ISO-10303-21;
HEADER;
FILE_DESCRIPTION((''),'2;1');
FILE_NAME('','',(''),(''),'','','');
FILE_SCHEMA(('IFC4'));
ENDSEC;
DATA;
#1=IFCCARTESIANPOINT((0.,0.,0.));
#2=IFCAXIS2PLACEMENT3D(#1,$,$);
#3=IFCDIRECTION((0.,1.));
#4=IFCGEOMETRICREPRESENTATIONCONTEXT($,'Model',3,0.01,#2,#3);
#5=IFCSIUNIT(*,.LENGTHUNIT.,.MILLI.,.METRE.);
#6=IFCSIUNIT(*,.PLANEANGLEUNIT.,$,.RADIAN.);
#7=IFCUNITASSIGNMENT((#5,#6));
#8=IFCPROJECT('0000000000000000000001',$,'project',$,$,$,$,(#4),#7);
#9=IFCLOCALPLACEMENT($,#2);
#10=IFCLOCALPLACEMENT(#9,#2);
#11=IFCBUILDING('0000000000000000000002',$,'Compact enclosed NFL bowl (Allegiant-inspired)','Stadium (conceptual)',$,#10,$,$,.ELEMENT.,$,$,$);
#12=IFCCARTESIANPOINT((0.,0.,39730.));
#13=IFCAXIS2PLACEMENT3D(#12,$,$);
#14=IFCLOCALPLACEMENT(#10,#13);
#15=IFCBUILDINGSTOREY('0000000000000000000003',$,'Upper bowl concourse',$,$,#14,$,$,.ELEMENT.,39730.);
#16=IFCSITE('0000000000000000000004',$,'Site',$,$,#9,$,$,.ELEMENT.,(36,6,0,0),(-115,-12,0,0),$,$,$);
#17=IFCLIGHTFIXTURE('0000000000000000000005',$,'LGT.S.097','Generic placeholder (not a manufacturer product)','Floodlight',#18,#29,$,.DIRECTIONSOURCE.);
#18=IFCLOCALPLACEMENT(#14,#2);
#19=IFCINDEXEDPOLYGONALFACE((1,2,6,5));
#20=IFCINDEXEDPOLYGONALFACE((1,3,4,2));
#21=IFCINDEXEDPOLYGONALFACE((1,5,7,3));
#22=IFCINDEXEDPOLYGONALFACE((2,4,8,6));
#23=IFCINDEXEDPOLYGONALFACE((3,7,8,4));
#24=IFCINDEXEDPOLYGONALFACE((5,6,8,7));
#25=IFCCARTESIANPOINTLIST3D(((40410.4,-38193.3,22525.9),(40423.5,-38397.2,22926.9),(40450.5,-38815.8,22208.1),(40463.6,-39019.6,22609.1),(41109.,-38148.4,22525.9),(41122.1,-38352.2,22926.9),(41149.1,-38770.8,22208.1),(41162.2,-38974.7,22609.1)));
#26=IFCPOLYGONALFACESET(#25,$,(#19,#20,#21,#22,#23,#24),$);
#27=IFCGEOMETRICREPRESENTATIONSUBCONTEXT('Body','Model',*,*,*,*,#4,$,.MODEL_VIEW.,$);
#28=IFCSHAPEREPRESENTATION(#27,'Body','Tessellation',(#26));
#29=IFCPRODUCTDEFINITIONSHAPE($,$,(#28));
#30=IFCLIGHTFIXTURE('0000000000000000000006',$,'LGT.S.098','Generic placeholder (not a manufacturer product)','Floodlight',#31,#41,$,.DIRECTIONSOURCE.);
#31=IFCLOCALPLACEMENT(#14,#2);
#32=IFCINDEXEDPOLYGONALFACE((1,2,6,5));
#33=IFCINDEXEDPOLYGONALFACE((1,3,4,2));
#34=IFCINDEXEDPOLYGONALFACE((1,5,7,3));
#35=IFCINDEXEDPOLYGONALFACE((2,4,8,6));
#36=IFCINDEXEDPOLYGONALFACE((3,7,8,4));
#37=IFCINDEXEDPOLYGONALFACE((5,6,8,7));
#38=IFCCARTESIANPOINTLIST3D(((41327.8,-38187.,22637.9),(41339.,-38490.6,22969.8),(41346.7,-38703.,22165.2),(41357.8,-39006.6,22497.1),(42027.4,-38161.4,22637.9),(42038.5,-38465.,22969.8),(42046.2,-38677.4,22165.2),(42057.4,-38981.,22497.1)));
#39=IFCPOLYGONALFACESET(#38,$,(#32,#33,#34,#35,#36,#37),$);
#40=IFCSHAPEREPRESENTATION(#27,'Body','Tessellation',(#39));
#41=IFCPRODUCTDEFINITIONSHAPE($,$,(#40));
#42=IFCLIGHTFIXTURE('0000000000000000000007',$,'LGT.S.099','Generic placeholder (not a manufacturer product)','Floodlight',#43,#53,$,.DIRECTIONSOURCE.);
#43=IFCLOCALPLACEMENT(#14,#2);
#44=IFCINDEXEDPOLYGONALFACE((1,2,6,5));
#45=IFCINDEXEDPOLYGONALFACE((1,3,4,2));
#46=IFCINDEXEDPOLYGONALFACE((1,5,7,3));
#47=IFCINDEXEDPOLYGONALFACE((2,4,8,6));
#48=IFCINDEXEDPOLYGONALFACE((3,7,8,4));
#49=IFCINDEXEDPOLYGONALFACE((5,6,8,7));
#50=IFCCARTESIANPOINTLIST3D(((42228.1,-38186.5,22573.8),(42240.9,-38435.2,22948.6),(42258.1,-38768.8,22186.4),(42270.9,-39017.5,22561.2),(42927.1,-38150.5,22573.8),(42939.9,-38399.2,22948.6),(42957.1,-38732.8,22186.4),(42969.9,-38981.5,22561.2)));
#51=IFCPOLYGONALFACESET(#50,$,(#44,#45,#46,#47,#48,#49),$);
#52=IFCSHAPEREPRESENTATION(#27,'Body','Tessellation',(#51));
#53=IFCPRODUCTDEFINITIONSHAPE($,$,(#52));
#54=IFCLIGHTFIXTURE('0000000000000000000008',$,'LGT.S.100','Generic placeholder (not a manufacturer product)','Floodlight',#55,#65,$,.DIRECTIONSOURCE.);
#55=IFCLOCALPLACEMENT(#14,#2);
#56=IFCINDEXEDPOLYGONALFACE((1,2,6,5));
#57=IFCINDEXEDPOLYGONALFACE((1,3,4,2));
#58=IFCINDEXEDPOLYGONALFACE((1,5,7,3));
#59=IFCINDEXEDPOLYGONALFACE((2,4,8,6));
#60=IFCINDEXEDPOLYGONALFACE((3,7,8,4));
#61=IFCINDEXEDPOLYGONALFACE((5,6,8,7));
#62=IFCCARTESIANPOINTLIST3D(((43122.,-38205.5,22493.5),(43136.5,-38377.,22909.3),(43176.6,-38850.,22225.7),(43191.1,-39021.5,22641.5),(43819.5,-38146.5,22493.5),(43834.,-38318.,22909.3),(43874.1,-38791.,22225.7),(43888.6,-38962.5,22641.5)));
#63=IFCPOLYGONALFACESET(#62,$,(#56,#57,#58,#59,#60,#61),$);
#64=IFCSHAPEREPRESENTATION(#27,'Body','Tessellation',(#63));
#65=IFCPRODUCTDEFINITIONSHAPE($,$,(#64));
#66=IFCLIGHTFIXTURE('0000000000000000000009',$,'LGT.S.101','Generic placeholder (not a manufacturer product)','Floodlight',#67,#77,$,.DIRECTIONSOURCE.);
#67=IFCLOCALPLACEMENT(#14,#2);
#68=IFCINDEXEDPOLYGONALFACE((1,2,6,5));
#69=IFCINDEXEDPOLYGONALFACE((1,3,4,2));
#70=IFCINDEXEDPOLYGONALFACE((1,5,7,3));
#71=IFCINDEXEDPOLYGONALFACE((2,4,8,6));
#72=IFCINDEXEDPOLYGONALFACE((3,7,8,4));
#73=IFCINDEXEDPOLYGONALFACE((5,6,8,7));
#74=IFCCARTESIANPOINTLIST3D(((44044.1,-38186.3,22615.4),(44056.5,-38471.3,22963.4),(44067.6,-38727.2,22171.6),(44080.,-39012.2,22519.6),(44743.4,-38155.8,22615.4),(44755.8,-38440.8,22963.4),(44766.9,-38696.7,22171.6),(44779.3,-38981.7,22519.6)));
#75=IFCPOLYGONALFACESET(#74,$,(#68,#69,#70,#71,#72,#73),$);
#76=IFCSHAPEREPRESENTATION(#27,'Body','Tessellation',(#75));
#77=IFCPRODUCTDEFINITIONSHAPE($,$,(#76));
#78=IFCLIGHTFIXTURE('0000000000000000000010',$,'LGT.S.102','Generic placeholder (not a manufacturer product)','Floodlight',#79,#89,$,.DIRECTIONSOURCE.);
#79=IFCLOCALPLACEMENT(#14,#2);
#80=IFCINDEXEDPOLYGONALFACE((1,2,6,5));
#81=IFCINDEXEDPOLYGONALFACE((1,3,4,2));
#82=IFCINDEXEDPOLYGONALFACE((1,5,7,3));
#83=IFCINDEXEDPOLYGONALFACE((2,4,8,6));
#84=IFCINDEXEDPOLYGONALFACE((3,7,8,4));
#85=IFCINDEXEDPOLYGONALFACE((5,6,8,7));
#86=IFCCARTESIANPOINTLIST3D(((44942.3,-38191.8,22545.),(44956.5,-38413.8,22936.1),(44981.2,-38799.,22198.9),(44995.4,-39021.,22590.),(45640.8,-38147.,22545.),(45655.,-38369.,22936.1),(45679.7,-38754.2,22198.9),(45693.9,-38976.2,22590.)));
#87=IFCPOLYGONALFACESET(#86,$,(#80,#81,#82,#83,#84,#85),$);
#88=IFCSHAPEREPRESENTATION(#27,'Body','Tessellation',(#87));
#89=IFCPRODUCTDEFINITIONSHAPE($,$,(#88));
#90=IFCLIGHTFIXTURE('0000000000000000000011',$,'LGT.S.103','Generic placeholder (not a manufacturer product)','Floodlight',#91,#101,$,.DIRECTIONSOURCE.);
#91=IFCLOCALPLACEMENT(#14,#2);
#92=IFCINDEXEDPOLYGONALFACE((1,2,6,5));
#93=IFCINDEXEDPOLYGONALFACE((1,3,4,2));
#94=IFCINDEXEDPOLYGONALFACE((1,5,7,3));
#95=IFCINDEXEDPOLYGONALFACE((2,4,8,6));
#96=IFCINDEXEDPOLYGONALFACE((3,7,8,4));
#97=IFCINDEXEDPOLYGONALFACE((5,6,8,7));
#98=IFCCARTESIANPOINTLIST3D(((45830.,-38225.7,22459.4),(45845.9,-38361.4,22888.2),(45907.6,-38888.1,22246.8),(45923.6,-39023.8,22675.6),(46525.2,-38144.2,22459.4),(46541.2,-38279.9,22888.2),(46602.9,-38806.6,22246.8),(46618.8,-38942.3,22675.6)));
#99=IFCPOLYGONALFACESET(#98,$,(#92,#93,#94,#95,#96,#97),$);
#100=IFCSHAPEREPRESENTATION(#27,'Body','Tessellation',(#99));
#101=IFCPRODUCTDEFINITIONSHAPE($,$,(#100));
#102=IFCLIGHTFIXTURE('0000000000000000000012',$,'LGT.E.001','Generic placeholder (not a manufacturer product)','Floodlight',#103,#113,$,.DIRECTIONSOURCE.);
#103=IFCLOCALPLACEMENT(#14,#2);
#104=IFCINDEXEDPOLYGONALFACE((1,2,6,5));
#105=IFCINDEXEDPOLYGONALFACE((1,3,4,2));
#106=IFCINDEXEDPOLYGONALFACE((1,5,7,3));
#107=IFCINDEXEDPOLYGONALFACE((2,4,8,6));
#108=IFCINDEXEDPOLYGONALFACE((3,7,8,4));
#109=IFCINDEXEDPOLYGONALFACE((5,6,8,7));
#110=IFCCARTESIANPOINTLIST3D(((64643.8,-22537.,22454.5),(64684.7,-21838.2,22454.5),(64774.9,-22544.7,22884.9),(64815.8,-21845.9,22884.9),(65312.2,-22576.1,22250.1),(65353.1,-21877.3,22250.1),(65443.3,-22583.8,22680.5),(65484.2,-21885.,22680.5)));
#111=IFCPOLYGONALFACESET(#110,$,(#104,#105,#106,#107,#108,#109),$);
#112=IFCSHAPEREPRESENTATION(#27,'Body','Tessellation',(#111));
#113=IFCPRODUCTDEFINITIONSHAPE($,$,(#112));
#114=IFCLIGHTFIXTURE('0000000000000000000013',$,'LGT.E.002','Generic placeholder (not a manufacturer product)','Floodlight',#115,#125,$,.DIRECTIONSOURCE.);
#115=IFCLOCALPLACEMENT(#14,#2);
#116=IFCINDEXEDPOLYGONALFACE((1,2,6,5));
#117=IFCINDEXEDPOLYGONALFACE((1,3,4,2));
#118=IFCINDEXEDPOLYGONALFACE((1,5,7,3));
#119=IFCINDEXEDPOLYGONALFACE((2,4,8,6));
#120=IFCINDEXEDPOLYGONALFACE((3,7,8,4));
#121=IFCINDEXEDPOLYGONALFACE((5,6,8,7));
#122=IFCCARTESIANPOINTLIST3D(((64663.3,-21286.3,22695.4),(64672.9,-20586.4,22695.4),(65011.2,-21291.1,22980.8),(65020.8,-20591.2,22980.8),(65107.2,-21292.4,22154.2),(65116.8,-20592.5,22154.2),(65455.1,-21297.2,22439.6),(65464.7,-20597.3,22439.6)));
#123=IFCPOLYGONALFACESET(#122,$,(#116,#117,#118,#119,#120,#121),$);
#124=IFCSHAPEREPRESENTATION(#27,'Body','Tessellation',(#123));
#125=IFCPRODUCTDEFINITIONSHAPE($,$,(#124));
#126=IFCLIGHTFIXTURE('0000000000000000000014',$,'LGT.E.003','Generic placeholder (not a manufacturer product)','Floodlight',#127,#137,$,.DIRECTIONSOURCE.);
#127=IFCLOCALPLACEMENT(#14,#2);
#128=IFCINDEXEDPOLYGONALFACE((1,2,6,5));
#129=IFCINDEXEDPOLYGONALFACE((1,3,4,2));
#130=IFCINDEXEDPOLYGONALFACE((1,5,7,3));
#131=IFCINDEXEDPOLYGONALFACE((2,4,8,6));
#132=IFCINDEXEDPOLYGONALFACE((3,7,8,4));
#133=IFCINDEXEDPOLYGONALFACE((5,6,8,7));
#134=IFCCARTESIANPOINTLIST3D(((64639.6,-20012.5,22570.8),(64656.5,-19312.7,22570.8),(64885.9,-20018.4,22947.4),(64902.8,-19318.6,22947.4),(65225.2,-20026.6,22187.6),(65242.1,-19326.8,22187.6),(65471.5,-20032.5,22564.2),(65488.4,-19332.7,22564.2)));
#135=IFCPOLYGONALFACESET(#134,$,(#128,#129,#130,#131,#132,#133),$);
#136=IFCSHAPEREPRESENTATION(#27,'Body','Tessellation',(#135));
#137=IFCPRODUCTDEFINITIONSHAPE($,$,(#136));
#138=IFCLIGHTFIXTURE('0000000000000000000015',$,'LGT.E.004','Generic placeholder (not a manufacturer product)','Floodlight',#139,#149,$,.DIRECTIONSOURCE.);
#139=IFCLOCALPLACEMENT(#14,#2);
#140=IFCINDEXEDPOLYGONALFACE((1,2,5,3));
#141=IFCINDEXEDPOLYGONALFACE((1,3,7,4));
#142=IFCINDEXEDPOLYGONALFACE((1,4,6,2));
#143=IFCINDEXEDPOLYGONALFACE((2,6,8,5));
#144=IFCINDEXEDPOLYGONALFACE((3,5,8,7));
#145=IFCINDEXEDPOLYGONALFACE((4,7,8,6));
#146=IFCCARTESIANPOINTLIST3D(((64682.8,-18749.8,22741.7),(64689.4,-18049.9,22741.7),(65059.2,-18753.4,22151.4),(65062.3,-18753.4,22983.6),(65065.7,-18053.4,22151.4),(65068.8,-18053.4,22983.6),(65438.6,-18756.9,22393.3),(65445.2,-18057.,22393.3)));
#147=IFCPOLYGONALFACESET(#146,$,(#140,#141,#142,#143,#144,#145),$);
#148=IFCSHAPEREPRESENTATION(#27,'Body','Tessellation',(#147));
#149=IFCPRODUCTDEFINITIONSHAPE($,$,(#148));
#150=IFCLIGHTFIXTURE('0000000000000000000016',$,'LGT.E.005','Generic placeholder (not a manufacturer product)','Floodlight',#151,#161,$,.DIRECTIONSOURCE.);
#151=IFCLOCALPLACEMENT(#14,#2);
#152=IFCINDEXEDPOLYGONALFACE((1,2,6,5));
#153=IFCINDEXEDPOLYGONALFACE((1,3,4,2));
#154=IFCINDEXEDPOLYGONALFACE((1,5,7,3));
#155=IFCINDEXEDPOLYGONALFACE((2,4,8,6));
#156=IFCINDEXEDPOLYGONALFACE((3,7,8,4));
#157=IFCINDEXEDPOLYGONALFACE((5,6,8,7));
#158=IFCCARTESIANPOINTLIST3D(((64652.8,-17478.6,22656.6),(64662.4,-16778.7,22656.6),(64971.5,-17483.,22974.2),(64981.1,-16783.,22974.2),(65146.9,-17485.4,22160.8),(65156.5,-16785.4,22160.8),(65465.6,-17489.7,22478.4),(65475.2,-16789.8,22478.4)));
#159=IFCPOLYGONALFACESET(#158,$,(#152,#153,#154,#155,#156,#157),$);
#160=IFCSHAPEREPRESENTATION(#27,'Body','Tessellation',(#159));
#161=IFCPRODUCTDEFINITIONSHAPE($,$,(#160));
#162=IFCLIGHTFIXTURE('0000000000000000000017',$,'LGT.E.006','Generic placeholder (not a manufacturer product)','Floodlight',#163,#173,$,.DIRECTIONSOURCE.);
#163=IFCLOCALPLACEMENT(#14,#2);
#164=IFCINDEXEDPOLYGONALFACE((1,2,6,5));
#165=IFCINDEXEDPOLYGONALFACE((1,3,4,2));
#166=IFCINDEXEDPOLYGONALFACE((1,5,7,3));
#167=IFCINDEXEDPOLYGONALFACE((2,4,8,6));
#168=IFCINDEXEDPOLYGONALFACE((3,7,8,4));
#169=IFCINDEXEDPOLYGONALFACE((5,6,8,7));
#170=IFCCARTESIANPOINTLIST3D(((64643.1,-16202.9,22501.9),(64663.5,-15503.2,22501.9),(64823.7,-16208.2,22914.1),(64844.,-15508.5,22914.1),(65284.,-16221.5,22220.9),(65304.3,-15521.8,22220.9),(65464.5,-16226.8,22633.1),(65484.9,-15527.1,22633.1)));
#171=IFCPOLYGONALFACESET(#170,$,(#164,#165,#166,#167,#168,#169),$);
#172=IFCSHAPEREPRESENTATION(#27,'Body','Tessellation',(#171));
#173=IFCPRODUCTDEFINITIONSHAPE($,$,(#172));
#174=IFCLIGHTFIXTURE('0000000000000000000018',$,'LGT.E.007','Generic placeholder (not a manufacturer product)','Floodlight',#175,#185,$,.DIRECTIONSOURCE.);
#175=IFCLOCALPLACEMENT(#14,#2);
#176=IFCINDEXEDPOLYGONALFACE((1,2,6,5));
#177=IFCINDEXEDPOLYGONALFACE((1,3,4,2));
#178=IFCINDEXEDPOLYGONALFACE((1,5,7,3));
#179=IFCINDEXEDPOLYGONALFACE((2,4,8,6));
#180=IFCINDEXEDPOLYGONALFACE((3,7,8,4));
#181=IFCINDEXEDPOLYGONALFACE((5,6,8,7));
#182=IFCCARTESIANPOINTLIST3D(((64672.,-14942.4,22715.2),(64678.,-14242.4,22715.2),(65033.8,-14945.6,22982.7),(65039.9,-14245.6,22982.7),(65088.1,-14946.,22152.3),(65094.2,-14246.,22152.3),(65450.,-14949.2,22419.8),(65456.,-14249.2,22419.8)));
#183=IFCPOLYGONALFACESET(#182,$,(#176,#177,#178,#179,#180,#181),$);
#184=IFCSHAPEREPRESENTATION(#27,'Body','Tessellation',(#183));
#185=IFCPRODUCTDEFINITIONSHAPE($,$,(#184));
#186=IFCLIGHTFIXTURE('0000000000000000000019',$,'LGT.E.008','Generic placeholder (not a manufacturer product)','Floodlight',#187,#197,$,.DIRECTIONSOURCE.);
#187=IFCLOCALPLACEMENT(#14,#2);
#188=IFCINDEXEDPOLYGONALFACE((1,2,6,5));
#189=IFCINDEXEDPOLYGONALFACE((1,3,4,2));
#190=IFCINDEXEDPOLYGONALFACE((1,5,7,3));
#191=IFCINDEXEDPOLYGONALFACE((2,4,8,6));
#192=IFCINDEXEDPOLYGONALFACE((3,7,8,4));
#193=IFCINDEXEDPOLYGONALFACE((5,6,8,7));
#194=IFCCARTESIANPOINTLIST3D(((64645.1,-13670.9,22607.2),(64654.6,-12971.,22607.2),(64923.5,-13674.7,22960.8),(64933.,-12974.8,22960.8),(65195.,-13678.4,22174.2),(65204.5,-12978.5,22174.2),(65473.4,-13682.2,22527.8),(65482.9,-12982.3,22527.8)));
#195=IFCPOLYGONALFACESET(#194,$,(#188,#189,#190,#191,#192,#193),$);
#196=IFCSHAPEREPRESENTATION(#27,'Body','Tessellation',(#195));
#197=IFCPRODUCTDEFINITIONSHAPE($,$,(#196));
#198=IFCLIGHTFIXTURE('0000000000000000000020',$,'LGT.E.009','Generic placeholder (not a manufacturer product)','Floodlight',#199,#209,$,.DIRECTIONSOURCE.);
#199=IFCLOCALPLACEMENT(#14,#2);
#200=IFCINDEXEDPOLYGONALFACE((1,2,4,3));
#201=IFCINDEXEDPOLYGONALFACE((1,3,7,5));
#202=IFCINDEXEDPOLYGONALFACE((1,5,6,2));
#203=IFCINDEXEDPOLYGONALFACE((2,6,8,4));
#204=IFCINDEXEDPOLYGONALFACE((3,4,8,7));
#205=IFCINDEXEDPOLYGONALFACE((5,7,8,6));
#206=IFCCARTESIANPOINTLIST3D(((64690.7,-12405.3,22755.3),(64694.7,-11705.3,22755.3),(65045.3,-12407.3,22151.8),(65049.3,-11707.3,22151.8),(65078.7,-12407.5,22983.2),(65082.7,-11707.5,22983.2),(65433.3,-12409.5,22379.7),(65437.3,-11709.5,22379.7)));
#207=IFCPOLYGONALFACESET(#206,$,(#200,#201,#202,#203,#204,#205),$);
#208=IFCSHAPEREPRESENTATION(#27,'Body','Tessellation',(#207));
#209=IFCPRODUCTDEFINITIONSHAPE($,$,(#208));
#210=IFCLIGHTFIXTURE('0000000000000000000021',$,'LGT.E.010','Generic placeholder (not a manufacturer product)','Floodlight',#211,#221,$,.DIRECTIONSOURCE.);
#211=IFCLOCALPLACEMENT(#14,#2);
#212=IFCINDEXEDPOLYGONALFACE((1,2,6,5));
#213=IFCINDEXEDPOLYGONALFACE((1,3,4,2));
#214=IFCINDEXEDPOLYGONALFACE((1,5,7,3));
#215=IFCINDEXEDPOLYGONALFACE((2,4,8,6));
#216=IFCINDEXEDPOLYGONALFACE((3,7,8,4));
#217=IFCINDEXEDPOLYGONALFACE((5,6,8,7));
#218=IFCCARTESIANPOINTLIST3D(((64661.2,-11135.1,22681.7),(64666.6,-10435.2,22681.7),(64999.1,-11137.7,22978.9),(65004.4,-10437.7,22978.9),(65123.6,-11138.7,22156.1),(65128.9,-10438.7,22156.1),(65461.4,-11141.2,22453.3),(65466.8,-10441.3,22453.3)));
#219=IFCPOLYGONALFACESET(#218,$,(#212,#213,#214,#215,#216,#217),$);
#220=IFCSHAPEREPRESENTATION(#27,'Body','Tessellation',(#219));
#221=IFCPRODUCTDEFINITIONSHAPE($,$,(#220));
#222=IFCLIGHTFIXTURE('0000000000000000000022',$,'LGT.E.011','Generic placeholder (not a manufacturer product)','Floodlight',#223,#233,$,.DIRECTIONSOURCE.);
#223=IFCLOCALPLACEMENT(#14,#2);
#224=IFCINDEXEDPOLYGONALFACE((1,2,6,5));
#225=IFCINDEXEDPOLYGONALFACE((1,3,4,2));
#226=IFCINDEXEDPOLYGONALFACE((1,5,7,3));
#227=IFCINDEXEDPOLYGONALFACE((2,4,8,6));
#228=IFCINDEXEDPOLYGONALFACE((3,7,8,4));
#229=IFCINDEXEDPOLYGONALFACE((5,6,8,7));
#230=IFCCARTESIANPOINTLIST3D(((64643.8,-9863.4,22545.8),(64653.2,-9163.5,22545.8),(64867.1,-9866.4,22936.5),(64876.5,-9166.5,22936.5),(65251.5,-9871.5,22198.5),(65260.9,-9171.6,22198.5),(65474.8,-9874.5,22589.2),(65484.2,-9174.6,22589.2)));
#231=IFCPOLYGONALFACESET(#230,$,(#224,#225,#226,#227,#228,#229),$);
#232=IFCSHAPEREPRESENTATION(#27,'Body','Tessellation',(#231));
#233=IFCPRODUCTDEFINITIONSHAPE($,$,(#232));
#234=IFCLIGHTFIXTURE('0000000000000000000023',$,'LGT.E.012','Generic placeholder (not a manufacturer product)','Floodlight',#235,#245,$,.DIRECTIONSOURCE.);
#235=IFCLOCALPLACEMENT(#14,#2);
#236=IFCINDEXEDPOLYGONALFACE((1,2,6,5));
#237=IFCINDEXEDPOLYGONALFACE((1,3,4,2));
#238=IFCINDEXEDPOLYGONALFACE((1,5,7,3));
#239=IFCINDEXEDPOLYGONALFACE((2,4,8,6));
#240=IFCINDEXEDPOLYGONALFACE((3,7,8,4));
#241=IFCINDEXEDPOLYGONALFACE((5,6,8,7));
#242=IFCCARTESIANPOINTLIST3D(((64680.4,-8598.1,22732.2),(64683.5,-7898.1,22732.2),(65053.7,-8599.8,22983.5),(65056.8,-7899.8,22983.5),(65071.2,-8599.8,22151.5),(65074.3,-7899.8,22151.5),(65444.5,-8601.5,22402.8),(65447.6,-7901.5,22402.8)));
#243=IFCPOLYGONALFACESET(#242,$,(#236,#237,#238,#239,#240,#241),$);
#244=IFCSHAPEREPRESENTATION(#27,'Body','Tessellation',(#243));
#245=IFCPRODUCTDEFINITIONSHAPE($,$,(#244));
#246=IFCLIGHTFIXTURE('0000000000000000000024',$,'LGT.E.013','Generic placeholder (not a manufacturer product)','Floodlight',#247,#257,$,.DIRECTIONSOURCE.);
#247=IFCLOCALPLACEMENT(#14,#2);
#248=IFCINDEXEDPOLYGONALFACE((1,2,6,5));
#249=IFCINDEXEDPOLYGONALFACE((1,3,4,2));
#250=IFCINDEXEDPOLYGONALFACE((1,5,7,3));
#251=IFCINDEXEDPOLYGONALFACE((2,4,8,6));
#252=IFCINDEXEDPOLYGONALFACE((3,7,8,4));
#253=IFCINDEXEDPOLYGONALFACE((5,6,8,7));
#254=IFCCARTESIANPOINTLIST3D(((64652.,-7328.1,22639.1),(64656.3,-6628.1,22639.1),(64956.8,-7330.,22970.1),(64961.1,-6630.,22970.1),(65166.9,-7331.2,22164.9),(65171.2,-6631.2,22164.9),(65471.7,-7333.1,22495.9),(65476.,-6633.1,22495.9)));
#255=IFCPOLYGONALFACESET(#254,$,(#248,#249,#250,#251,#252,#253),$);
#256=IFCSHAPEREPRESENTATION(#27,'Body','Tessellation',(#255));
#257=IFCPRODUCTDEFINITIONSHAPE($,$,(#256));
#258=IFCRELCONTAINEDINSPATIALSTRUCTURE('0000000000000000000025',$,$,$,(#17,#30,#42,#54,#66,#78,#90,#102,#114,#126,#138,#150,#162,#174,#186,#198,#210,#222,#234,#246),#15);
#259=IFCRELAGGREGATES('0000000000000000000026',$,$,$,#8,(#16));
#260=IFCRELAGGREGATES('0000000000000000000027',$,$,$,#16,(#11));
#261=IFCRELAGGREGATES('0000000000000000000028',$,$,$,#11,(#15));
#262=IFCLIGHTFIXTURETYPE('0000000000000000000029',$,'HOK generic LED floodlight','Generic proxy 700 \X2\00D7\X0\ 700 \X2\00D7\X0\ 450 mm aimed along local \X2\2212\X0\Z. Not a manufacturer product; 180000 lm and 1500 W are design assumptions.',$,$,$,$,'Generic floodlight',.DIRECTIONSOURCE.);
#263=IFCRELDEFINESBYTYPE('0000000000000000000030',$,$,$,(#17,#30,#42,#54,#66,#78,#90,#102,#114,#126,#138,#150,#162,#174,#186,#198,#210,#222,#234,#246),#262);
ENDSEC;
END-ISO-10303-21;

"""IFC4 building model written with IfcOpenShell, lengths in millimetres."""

from ifc_helpers import new_model, si_unit, direction, frame, origin, place, context, subcontext, project, spatial, rectangle, extrude, source, transform, mapped, type_object, type_shapes, element, save


model = new_model("IFC4")

# Units and contexts
model_context = context("Model", 3, precision=0.01, world=origin(), true_north=direction((0.0, 1.0)))
body_context = subcontext(model_context, "Body", "Model", "MODEL_VIEW")
ifc_project = project(units=[si_unit("LENGTHUNIT", "METRE", prefix="MILLI"), si_unit("PLANEANGLEUNIT", "RADIAN")], contexts=[model_context])

# Site, building, storey
site_placement = place(None, origin())
site = spatial("IfcSite", under=ifc_project, at=site_placement, Name="Site", CompositionType="ELEMENT", RefLatitude=(36, 6, 0, 0), RefLongitude=(-115, -12, 0, 0))
building_placement = place(site_placement, origin())
building = spatial("IfcBuilding", under=site, at=building_placement, Name="Compact enclosed NFL bowl (Allegiant-inspired)", Description="Stadium (conceptual)", CompositionType="ELEMENT")
storey_placement = place(building_placement, frame((0.0, 0.0, 39730.0)))
storey = spatial("IfcBuildingStorey", under=building, at=storey_placement, Name="Upper bowl concourse", CompositionType="ELEMENT", Elevation=39730.0)

# Light fixtures
light_fixture_type = type_object("IfcLightFixtureType", Name="HOK generic LED floodlight", Description="Generic proxy 700 × 700 × 450 mm aimed along local −Z. Not a manufacturer product; 180000 lm and 1500 W are design assumptions.", ElementType="Generic floodlight", PredefinedType="DIRECTIONSOURCE")
shared_shape = source(origin(), body_context, "Body", "SweptSolid", [
    extrude(rectangle(XDim=700.0, YDim=700.0), frame((0.0, 0.0, -225.0)), (0.0, 0.0, 1.0), 450.0),
])
type_shapes(light_fixture_type, [shared_shape])
for number, where, z_axis, x_axis, name in (
    (1, (40786.3, -38584.0, 22567.5), (0.029168, -0.452997, 0.891035), (0.997933, 0.064256, 0.0), "LGT.S.097"),
    (2, (41692.6, -38584.0, 22567.5), (0.024683, -0.674769, 0.737616), (0.999332, 0.036555, 0.0), "LGT.S.098"),
    (3, (42599.0, -38584.0, 22567.5), (0.028476, -0.552721, 0.83288), (0.998675, 0.051452, 0.0), "LGT.S.099"),
    (4, (43505.3, -38584.0, 22567.5), (0.032263, -0.381097, 0.923972), (0.996436, 0.084356, 0.0), "LGT.S.100"),
    (5, (44411.7, -38584.0, 22567.5), (0.027568, -0.63331, 0.773407), (0.999054, 0.043489, 0.0), "LGT.S.101"),
    (6, (45318.1, -38584.0, 22567.5), (0.031615, -0.493437, 0.869206), (0.997954, 0.06394, 0.0), "LGT.S.102"),
    (7, (46224.4, -38584.0, 22567.5), (0.035348, -0.301573, 0.952788), (0.993201, 0.116416, 0.0), "LGT.S.103"),
    (8, (65064.0, -22211.0, 22567.5), (0.291374, -0.01705, 0.956457), (0.058417, 0.998292, 0.0), "LGT.E.001"),
    (9, (65064.0, -20941.8, 22567.5), (0.773104, -0.010659, 0.634189), (0.013786, 0.999905, 0.0), "LGT.E.002"),
    (10, (65064.0, -19672.6, 22567.5), (0.547239, -0.013214, 0.836872), (0.024139, 0.999709, 0.0), "LGT.E.003"),
    (11, (65064.0, -18403.4, 22567.5), (0.843152, -0.007941, 0.537616), (0.009418, 0.999956, 0.0), "LGT.E.004"),
    (12, (65064.0, -17134.2, 22567.5), (0.708196, -0.009708, 0.705949), (0.013707, 0.999906, 0.0), "LGT.E.005"),
    (13, (65064.0, -15865.0, 22567.5), (0.401213, -0.011663, 0.91591), (0.029056, 0.999578, 0.0), "LGT.E.006"),
    (14, (65064.0, -14595.8, 22567.5), (0.804054, -0.006965, 0.594515), (0.008661, 0.999962, 0.0), "LGT.E.007"),
    (15, (65064.0, -13326.6, 22567.5), (0.61858, -0.008404, 0.785677), (0.013584, 0.999908, 0.0), "LGT.E.008"),
    (16, (65064.0, -12057.4, 22567.5), (0.862149, -0.004903, 0.506632), (0.005687, 0.999984, 0.0), "LGT.E.009"),
    (17, (65064.0, -10788.2, 22567.5), (0.750767, -0.005719, 0.660542), (0.007618, 0.999971, 0.0), "LGT.E.010"),
    (18, (65064.0, -9519.0, 22567.5), (0.496148, -0.006633, 0.868213), (0.013368, 0.999911, 0.0), "LGT.E.011"),
    (19, (65064.0, -8249.8, 22567.5), (0.829608, -0.003697, 0.558334), (0.004456, 0.99999, 0.0), "LGT.E.012"),
    (20, (65064.0, -6980.6, 22567.5), (0.677342, -0.004122, 0.735657), (0.006085, 0.999981, 0.0), "LGT.E.013"),
):
    element("IfcLightFixture", number, at=place(storey_placement, frame(where, z_axis=z_axis, x_axis=x_axis)), inside=storey, type_object=light_fixture_type, Name=name, Description="Generic placeholder (not a manufacturer product)", ObjectType="Floodlight", PredefinedType="DIRECTIONSOURCE", context=body_context, shape_type="MappedRepresentation", body=[
        mapped(shared_shape, transform((0.0, 0.0, 0.0))),
    ])

save(model, "model.ifc")
